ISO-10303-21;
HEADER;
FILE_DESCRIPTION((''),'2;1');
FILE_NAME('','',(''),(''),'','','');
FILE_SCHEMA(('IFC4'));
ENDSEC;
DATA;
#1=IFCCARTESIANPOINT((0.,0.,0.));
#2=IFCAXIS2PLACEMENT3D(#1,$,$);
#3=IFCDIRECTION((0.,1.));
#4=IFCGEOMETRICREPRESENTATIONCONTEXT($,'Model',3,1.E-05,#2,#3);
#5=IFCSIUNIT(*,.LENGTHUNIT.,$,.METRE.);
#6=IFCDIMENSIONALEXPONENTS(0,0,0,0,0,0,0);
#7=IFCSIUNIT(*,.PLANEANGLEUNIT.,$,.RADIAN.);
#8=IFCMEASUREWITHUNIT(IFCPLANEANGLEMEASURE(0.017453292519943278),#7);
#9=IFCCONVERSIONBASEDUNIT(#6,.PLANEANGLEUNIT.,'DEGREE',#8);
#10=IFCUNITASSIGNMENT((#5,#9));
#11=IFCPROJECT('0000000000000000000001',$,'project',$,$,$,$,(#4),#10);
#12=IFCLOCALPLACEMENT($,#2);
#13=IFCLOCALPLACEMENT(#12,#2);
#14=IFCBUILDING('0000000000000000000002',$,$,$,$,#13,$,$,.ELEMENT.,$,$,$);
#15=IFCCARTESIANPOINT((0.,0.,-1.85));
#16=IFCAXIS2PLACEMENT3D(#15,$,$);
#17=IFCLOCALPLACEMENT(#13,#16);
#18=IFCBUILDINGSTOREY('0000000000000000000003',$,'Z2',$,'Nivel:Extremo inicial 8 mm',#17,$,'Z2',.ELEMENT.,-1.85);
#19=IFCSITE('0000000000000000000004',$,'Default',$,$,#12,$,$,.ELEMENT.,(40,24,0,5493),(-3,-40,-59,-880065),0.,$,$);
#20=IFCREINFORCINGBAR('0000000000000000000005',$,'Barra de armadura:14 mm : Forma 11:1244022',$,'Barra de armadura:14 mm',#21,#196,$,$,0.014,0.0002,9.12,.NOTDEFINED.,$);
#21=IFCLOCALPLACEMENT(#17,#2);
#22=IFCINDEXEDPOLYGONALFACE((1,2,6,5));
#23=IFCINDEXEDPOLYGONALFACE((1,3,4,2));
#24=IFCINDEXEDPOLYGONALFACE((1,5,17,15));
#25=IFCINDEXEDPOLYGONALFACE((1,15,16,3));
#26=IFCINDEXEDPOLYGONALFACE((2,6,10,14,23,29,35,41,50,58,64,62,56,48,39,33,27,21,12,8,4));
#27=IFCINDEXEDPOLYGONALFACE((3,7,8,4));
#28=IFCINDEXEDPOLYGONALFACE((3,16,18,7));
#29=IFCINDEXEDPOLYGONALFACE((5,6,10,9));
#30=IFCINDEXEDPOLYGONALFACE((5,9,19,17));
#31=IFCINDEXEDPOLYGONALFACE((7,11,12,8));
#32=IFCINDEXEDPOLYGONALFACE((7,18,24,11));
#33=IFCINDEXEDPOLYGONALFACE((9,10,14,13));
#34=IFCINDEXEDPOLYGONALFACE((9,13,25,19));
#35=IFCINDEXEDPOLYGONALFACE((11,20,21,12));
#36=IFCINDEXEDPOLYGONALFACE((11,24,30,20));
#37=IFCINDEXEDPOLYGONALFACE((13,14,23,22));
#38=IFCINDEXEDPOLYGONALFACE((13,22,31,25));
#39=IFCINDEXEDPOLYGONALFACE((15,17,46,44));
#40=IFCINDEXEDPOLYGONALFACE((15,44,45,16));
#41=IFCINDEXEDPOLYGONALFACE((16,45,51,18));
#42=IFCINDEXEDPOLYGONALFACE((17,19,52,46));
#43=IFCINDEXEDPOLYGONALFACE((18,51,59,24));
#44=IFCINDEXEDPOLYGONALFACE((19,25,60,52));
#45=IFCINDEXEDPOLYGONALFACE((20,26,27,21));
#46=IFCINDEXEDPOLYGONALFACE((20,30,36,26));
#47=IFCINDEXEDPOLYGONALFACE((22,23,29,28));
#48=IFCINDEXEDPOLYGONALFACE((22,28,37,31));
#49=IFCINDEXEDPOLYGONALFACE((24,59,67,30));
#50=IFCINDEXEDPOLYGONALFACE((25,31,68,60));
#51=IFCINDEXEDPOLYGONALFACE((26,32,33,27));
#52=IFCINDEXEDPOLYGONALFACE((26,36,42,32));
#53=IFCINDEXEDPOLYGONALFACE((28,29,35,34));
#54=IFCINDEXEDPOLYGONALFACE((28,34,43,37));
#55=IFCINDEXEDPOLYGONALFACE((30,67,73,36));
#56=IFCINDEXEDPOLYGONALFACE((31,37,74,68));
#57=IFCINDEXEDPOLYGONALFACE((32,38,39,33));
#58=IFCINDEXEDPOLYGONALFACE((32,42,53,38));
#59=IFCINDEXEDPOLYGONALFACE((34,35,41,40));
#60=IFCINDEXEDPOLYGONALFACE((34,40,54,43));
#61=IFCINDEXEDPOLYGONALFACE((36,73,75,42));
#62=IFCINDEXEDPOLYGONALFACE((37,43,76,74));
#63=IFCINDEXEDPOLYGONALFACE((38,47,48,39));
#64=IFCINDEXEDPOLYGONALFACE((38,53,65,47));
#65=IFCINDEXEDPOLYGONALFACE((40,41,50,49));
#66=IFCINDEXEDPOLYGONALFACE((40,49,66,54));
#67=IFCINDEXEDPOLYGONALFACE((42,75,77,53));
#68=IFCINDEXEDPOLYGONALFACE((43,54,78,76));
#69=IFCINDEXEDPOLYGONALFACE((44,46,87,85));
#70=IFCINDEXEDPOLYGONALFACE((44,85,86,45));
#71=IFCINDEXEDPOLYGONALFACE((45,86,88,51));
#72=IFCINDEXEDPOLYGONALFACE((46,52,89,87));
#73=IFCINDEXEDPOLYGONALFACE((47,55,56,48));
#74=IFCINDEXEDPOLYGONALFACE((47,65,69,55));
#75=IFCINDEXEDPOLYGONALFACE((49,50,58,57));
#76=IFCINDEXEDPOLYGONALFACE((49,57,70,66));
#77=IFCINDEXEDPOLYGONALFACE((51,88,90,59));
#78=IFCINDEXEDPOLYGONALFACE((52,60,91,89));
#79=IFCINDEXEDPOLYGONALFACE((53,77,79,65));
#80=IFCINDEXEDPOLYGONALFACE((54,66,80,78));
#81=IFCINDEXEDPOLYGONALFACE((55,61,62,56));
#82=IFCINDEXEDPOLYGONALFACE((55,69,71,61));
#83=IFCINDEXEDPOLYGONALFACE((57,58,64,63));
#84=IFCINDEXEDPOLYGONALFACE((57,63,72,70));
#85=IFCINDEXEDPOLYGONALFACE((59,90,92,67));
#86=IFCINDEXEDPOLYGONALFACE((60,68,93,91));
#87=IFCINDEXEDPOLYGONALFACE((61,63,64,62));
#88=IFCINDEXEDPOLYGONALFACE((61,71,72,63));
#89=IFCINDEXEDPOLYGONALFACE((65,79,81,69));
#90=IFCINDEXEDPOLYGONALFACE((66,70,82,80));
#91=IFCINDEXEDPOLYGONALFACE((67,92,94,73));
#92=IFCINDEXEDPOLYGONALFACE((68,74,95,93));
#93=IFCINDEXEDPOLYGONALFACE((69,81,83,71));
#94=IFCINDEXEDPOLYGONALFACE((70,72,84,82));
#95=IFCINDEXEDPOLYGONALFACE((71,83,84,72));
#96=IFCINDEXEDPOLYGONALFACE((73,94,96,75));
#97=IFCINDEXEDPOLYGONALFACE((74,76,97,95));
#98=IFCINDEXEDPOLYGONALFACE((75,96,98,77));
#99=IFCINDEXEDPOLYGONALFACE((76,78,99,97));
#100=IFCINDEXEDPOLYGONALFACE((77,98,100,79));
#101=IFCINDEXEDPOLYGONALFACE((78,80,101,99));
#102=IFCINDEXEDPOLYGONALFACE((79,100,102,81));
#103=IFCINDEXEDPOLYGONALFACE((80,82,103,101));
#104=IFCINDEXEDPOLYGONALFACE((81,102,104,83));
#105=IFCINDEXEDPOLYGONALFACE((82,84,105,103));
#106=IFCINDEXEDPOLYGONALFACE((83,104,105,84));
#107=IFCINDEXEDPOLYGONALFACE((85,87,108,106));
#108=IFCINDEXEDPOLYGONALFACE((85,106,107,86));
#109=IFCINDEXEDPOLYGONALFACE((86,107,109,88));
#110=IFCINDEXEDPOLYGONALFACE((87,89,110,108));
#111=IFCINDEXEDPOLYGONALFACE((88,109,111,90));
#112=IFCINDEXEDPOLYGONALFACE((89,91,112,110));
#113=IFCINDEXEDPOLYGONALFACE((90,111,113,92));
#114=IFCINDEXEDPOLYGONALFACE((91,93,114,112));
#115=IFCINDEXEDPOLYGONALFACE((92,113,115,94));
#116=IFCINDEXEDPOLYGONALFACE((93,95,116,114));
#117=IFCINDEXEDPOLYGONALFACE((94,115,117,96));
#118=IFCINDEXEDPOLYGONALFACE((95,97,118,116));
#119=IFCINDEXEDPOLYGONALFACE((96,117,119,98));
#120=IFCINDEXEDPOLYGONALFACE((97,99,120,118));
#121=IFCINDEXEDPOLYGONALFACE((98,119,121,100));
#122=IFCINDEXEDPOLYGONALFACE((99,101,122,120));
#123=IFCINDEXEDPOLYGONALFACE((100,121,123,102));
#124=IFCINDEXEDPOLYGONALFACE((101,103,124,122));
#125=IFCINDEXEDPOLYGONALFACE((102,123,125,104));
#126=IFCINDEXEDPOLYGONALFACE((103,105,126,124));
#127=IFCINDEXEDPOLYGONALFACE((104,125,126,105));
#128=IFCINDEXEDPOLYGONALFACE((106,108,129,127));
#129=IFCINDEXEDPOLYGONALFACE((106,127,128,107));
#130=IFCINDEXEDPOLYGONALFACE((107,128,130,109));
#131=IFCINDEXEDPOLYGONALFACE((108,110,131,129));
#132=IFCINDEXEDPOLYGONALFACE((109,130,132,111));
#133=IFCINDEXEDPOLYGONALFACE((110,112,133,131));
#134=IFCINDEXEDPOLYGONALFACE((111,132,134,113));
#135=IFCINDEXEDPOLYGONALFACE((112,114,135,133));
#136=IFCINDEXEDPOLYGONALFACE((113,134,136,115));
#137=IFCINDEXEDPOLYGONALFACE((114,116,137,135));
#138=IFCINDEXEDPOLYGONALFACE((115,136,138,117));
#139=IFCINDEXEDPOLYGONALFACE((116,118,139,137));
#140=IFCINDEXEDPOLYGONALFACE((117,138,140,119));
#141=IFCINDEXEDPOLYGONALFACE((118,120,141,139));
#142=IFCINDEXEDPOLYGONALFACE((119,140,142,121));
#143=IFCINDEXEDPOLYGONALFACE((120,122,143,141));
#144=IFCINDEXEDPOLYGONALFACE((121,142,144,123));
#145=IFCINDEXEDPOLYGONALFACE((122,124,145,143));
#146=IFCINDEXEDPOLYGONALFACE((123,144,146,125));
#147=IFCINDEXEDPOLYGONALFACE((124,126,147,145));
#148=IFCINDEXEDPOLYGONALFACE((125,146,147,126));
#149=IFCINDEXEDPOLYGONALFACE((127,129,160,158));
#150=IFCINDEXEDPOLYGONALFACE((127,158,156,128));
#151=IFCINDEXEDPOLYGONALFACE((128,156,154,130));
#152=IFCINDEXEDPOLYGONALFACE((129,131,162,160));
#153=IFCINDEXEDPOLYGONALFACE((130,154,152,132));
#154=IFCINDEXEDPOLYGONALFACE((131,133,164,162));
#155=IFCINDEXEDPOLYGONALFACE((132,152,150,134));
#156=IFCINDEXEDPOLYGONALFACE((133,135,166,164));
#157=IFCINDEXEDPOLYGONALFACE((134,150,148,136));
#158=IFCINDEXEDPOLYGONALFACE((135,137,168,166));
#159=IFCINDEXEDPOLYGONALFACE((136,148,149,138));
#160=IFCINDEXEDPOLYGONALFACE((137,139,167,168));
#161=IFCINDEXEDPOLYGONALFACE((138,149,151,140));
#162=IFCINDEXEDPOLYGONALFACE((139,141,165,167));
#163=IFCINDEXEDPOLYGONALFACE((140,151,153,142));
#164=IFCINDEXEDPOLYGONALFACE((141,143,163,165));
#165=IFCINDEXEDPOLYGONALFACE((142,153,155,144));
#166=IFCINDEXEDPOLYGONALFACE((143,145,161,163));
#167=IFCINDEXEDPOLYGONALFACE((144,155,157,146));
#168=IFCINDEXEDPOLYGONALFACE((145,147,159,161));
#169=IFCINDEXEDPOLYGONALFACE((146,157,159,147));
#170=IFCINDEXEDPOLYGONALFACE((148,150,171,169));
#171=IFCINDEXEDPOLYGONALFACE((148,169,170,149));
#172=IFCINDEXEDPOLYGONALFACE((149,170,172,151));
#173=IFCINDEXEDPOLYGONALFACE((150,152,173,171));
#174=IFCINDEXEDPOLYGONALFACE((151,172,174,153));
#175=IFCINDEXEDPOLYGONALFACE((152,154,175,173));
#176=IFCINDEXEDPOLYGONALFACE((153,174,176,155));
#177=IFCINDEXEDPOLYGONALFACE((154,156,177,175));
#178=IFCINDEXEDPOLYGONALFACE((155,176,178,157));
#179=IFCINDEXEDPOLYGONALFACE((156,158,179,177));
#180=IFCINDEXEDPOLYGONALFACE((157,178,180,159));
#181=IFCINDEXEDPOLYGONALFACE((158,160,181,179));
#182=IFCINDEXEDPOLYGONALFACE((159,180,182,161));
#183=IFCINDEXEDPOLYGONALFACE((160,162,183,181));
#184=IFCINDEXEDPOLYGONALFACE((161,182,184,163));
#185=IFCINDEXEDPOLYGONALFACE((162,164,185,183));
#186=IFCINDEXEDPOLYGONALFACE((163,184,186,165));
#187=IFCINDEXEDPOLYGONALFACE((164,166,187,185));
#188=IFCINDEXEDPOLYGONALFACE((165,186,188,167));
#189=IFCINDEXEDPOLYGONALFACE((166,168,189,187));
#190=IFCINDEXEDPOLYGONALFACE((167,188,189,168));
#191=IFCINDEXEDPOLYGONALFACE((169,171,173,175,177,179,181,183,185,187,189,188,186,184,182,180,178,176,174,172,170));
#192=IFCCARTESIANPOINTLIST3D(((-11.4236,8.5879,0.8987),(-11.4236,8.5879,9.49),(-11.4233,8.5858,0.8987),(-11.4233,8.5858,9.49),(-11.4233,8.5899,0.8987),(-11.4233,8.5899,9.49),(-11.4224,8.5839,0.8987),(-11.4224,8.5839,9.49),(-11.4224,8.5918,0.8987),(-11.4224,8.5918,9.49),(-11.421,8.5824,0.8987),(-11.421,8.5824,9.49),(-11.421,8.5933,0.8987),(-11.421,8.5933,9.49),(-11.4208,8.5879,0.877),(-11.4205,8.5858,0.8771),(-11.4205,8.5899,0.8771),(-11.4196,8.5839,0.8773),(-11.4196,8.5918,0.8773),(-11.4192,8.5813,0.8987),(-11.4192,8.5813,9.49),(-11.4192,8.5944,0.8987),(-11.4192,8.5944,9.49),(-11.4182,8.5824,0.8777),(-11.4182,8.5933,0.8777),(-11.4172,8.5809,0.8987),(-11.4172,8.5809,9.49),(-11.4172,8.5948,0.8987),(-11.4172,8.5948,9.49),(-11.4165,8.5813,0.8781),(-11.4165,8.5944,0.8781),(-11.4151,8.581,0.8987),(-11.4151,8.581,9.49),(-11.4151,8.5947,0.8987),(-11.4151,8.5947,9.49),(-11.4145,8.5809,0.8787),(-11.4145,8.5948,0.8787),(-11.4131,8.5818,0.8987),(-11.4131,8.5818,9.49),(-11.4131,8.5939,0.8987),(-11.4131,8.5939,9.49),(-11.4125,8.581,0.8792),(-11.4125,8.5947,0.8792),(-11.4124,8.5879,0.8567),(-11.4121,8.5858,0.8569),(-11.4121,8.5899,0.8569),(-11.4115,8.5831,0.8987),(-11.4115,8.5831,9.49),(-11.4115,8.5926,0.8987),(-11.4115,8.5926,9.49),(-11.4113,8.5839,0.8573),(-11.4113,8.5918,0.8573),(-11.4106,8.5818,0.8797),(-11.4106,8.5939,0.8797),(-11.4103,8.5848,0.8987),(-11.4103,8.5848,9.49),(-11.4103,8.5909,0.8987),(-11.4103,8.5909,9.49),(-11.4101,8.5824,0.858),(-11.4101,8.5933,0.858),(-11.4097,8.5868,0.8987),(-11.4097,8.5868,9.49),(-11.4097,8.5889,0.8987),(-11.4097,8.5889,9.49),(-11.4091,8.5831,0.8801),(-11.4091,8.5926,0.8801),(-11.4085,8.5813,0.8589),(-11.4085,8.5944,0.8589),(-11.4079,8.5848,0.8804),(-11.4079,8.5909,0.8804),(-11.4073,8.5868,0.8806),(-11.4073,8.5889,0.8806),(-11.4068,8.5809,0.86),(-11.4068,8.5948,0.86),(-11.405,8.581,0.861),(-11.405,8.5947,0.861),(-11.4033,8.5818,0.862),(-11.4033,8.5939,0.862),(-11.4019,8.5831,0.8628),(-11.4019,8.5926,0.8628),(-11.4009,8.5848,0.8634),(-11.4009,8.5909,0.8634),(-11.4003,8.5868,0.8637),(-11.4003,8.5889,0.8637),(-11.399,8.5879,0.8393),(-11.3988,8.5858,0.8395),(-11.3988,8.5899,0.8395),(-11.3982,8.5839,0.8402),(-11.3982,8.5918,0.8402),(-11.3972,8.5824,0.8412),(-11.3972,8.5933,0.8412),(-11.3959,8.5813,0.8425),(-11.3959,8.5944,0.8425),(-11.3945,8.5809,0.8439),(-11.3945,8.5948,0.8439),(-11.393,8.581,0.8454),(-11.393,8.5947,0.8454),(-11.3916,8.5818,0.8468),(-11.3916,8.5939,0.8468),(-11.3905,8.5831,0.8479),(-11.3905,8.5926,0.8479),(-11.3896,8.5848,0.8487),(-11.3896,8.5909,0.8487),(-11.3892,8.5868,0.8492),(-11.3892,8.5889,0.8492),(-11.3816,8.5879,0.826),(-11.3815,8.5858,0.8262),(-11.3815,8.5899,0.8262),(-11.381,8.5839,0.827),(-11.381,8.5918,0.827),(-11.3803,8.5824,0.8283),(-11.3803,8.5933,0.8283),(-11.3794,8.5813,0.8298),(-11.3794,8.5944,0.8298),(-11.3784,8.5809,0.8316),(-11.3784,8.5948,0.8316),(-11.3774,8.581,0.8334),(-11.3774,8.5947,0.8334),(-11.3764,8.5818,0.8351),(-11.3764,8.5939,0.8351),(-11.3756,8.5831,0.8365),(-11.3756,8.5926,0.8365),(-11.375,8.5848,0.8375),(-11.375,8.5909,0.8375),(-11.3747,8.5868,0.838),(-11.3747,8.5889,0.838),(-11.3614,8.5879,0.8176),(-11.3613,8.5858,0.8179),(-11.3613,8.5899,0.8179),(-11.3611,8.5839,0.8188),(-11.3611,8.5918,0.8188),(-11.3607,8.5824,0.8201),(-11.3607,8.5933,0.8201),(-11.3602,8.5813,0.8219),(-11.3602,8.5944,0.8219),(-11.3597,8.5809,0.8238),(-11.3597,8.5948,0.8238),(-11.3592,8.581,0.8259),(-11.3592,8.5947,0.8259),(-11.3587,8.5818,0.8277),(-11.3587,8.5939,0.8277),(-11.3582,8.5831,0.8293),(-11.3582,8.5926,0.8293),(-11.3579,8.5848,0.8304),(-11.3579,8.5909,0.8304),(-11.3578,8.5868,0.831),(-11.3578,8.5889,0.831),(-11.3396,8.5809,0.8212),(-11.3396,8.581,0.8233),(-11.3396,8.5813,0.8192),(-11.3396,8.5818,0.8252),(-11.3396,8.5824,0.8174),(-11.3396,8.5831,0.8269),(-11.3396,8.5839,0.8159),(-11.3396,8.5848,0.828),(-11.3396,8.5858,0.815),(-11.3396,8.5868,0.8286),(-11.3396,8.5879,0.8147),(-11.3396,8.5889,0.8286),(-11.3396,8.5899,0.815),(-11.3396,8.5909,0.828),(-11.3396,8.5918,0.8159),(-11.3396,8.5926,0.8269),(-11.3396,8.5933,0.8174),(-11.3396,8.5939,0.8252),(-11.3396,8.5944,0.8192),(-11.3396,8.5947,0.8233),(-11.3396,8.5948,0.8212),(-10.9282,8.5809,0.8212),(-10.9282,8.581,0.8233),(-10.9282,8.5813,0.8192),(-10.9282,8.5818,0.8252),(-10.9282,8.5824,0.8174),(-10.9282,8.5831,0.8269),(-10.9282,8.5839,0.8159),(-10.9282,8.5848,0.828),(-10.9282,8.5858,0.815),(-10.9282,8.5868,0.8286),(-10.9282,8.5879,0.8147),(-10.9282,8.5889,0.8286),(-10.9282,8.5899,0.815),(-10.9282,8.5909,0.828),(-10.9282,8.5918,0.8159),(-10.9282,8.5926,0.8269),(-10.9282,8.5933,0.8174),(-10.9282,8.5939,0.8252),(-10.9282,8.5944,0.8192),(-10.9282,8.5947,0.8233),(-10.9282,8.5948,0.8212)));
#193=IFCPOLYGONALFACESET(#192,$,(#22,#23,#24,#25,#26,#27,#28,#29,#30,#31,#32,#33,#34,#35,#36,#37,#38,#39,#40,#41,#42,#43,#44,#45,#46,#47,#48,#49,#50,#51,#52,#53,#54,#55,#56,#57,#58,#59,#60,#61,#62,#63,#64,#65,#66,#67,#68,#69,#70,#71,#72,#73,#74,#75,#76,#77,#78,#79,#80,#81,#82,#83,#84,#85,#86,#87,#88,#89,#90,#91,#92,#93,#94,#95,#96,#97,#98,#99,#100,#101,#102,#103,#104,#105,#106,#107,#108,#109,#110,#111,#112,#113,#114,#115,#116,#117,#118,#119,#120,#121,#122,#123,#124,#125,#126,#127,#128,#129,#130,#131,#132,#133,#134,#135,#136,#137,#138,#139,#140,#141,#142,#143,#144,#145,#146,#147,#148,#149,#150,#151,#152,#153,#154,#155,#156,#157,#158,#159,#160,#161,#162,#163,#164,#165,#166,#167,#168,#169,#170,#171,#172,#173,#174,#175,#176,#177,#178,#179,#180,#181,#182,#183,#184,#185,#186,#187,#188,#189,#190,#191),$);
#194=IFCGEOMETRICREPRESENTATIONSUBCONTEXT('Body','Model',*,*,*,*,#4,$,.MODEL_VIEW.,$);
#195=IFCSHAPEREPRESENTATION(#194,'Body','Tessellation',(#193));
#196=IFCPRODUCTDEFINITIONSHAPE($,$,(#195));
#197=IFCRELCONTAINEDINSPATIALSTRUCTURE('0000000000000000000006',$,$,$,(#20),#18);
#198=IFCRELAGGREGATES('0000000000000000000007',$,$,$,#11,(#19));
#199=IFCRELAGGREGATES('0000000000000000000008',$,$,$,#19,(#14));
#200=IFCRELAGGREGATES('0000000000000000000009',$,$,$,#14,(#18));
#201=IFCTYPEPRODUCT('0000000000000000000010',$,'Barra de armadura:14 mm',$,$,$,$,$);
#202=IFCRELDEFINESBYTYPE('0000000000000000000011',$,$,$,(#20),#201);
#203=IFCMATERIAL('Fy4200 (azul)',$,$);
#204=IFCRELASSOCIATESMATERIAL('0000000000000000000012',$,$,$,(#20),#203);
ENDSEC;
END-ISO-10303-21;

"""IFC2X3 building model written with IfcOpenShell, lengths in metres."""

from ifc_helpers import new_model, entity, si_unit, converted_unit, direction, frame, origin, place, context, subcontext, project, spatial, material, type_object, element, save


model = new_model("IFC2X3")

# Units and contexts
model_context = context("Model", 3, precision=1e-05, world=origin(), true_north=direction((0.0, 1.0)))
body_context = subcontext(model_context, "Body", "Model", "MODEL_VIEW")
ifc_project = project(units=[si_unit("LENGTHUNIT", "METRE"), converted_unit("PLANEANGLEUNIT", "DEGREE", entity("IfcPlaneAngleMeasure", 0.017453292519943278), si_unit("PLANEANGLEUNIT", "RADIAN"), dimensions=[0, 0, 0, 0, 0, 0, 0])], contexts=[model_context])

# Site, building, storey
site_placement = place(None, origin())
site = spatial("IfcSite", under=ifc_project, at=site_placement, Name="Default", CompositionType="ELEMENT", RefLatitude=(40, 24, 0, 5493), RefLongitude=(-3, -40, -59, -880065), RefElevation=0.0)
building_placement = place(site_placement, origin())
building = spatial("IfcBuilding", under=site, at=building_placement, CompositionType="ELEMENT")
storey_placement = place(building_placement, frame((0.0, 0.0, -1.85)))
storey = spatial("IfcBuildingStorey", under=building, at=storey_placement, Name="Z2", ObjectType="Nivel:Extremo inicial 8 mm", LongName="Z2", CompositionType="ELEMENT", Elevation=-1.85)

# Reinforcing bar
ifc_material_1 = material(Name="Fy4200 (azul)")
type_product_1 = type_object("IfcTypeProduct", Name="Barra de armadura:14 mm")
reinforcing_bar_1_placement = place(storey_placement, origin())
element("IfcReinforcingBar", 1, at=reinforcing_bar_1_placement, inside=storey, type_object=type_product_1, material=ifc_material_1, Name="Barra de armadura:14 mm : Forma 11:1244022", ObjectType="Barra de armadura:14 mm", BarLength=9.12, BarRole="NOTDEFINED", CrossSectionArea=0.0002, NominalDiameter=0.014, context=body_context, shape_type="AdvancedSweptSolid", body=[
    entity("IfcSweptDiskSolid", entity("IfcCompositeCurve", [entity("IfcCompositeCurveSegment", "CONTINUOUS", True, entity("IfcPolyline", [entity("IfcCartesianPoint", [-11.4166, 8.5879, 9.49]), entity("IfcCartesianPoint", [-11.4166, 8.5879, 0.8987])])), entity("IfcCompositeCurveSegment", "CONTINUOUS", True, entity("IfcTrimmedCurve", entity("IfcCircle", entity("IfcAxis2Placement3D", entity("IfcCartesianPoint", [-11.3396, 8.5879, 0.8987]), entity("IfcDirection", [0.0, -1.0, 0.0]), entity("IfcDirection", [0.0, 0.0, -1.0])), 0.077), [entity("IfcParameterValue", 270.0)], [entity("IfcParameterValue", 360.0)], True, "PARAMETER")), entity("IfcCompositeCurveSegment", "CONTINUOUS", True, entity("IfcPolyline", [entity("IfcCartesianPoint", [-11.3396, 8.5879, 0.8217]), entity("IfcCartesianPoint", [-10.9282, 8.5879, 0.8217])]))], False), 0.007, None, 0.0, 92.0),
])

save(model, "model.ifc")
